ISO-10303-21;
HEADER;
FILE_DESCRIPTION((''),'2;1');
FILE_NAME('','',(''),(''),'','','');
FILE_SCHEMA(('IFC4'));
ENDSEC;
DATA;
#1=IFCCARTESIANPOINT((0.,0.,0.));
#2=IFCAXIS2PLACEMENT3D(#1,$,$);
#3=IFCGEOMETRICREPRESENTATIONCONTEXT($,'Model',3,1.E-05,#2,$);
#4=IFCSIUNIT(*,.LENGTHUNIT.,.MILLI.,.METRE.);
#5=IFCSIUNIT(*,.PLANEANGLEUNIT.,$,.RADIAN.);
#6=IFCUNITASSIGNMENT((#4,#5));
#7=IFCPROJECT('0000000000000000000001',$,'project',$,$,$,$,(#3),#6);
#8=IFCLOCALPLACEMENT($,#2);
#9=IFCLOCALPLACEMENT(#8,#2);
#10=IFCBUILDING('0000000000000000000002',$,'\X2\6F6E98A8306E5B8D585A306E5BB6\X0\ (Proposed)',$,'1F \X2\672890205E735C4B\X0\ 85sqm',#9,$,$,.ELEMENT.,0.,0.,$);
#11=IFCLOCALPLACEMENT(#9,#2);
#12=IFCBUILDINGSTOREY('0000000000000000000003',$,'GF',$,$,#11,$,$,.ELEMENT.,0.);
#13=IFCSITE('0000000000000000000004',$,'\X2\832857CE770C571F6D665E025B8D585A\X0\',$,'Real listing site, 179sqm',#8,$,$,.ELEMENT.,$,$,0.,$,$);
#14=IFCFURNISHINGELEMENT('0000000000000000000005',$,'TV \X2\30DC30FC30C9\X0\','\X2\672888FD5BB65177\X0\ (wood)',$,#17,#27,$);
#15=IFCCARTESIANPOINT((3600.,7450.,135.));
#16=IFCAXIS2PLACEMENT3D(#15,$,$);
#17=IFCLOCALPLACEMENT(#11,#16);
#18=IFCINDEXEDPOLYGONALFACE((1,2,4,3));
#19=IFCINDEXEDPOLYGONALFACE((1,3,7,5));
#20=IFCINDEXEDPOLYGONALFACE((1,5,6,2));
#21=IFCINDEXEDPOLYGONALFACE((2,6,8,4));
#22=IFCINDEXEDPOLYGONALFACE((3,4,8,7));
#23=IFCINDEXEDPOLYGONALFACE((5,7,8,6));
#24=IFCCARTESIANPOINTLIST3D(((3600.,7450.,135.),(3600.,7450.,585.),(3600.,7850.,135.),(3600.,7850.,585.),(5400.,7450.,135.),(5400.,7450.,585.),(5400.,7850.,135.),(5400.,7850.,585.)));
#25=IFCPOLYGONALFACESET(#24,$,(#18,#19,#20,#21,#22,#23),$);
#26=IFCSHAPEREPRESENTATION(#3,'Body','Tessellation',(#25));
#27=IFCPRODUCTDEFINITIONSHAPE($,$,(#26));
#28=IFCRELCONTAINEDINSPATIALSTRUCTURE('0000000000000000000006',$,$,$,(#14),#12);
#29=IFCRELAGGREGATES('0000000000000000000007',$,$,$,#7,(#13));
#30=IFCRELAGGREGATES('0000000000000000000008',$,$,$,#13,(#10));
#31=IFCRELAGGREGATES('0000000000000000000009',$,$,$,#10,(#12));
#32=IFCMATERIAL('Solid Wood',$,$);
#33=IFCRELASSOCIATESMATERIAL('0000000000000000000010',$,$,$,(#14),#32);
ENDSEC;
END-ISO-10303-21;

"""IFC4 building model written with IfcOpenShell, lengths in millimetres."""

from ifc_helpers import new_model, si_unit, frame, frame_2d, origin, place, context, project, spatial, rectangle, extrude, material, element, save


model = new_model("IFC4")

# Units and contexts
model_context = context("Model", 3, precision=1e-05, world=origin())
ifc_project = project(units=[si_unit("LENGTHUNIT", "METRE", prefix="MILLI"), si_unit("PLANEANGLEUNIT", "RADIAN")], contexts=[model_context])

# Site, building, storey
site_placement = place(None, origin())
site = spatial("IfcSite", under=ifc_project, at=site_placement, Name="茨城県土浦市宍塚", ObjectType="Real listing site, 179sqm", CompositionType="ELEMENT", RefElevation=0.0)
building_placement = place(site_placement, origin())
building = spatial("IfcBuilding", under=site, at=building_placement, Name="潮風の宍塚の家 (Proposed)", ObjectType="1F 木造平屋 85sqm", CompositionType="ELEMENT", ElevationOfRefHeight=0.0, ElevationOfTerrain=0.0)
storey_placement = place(building_placement, origin())
storey = spatial("IfcBuildingStorey", under=building, at=storey_placement, Name="GF", CompositionType="ELEMENT", Elevation=0.0)

# Shared definitions
ifc_material_1 = material(Name="Solid Wood")

# Furnishing element
furnishing_1_placement = place(storey_placement, frame((3600.0, 7450.0, 135.0)))
element("IfcFurnishingElement", 1, at=furnishing_1_placement, inside=storey, material=ifc_material_1, Name="TV ボード", Description="木製家具 (wood)", context=model_context, shape_type="SweptSolid", body=[
    extrude(rectangle(XDim=1800.0, YDim=400.0, at=frame_2d((900.0, 200.0))), frame((3600.0, 7450.0, 135.0)), (0.0, 0.0, 1.0), 450.0),
])

save(model, "model.ifc")
